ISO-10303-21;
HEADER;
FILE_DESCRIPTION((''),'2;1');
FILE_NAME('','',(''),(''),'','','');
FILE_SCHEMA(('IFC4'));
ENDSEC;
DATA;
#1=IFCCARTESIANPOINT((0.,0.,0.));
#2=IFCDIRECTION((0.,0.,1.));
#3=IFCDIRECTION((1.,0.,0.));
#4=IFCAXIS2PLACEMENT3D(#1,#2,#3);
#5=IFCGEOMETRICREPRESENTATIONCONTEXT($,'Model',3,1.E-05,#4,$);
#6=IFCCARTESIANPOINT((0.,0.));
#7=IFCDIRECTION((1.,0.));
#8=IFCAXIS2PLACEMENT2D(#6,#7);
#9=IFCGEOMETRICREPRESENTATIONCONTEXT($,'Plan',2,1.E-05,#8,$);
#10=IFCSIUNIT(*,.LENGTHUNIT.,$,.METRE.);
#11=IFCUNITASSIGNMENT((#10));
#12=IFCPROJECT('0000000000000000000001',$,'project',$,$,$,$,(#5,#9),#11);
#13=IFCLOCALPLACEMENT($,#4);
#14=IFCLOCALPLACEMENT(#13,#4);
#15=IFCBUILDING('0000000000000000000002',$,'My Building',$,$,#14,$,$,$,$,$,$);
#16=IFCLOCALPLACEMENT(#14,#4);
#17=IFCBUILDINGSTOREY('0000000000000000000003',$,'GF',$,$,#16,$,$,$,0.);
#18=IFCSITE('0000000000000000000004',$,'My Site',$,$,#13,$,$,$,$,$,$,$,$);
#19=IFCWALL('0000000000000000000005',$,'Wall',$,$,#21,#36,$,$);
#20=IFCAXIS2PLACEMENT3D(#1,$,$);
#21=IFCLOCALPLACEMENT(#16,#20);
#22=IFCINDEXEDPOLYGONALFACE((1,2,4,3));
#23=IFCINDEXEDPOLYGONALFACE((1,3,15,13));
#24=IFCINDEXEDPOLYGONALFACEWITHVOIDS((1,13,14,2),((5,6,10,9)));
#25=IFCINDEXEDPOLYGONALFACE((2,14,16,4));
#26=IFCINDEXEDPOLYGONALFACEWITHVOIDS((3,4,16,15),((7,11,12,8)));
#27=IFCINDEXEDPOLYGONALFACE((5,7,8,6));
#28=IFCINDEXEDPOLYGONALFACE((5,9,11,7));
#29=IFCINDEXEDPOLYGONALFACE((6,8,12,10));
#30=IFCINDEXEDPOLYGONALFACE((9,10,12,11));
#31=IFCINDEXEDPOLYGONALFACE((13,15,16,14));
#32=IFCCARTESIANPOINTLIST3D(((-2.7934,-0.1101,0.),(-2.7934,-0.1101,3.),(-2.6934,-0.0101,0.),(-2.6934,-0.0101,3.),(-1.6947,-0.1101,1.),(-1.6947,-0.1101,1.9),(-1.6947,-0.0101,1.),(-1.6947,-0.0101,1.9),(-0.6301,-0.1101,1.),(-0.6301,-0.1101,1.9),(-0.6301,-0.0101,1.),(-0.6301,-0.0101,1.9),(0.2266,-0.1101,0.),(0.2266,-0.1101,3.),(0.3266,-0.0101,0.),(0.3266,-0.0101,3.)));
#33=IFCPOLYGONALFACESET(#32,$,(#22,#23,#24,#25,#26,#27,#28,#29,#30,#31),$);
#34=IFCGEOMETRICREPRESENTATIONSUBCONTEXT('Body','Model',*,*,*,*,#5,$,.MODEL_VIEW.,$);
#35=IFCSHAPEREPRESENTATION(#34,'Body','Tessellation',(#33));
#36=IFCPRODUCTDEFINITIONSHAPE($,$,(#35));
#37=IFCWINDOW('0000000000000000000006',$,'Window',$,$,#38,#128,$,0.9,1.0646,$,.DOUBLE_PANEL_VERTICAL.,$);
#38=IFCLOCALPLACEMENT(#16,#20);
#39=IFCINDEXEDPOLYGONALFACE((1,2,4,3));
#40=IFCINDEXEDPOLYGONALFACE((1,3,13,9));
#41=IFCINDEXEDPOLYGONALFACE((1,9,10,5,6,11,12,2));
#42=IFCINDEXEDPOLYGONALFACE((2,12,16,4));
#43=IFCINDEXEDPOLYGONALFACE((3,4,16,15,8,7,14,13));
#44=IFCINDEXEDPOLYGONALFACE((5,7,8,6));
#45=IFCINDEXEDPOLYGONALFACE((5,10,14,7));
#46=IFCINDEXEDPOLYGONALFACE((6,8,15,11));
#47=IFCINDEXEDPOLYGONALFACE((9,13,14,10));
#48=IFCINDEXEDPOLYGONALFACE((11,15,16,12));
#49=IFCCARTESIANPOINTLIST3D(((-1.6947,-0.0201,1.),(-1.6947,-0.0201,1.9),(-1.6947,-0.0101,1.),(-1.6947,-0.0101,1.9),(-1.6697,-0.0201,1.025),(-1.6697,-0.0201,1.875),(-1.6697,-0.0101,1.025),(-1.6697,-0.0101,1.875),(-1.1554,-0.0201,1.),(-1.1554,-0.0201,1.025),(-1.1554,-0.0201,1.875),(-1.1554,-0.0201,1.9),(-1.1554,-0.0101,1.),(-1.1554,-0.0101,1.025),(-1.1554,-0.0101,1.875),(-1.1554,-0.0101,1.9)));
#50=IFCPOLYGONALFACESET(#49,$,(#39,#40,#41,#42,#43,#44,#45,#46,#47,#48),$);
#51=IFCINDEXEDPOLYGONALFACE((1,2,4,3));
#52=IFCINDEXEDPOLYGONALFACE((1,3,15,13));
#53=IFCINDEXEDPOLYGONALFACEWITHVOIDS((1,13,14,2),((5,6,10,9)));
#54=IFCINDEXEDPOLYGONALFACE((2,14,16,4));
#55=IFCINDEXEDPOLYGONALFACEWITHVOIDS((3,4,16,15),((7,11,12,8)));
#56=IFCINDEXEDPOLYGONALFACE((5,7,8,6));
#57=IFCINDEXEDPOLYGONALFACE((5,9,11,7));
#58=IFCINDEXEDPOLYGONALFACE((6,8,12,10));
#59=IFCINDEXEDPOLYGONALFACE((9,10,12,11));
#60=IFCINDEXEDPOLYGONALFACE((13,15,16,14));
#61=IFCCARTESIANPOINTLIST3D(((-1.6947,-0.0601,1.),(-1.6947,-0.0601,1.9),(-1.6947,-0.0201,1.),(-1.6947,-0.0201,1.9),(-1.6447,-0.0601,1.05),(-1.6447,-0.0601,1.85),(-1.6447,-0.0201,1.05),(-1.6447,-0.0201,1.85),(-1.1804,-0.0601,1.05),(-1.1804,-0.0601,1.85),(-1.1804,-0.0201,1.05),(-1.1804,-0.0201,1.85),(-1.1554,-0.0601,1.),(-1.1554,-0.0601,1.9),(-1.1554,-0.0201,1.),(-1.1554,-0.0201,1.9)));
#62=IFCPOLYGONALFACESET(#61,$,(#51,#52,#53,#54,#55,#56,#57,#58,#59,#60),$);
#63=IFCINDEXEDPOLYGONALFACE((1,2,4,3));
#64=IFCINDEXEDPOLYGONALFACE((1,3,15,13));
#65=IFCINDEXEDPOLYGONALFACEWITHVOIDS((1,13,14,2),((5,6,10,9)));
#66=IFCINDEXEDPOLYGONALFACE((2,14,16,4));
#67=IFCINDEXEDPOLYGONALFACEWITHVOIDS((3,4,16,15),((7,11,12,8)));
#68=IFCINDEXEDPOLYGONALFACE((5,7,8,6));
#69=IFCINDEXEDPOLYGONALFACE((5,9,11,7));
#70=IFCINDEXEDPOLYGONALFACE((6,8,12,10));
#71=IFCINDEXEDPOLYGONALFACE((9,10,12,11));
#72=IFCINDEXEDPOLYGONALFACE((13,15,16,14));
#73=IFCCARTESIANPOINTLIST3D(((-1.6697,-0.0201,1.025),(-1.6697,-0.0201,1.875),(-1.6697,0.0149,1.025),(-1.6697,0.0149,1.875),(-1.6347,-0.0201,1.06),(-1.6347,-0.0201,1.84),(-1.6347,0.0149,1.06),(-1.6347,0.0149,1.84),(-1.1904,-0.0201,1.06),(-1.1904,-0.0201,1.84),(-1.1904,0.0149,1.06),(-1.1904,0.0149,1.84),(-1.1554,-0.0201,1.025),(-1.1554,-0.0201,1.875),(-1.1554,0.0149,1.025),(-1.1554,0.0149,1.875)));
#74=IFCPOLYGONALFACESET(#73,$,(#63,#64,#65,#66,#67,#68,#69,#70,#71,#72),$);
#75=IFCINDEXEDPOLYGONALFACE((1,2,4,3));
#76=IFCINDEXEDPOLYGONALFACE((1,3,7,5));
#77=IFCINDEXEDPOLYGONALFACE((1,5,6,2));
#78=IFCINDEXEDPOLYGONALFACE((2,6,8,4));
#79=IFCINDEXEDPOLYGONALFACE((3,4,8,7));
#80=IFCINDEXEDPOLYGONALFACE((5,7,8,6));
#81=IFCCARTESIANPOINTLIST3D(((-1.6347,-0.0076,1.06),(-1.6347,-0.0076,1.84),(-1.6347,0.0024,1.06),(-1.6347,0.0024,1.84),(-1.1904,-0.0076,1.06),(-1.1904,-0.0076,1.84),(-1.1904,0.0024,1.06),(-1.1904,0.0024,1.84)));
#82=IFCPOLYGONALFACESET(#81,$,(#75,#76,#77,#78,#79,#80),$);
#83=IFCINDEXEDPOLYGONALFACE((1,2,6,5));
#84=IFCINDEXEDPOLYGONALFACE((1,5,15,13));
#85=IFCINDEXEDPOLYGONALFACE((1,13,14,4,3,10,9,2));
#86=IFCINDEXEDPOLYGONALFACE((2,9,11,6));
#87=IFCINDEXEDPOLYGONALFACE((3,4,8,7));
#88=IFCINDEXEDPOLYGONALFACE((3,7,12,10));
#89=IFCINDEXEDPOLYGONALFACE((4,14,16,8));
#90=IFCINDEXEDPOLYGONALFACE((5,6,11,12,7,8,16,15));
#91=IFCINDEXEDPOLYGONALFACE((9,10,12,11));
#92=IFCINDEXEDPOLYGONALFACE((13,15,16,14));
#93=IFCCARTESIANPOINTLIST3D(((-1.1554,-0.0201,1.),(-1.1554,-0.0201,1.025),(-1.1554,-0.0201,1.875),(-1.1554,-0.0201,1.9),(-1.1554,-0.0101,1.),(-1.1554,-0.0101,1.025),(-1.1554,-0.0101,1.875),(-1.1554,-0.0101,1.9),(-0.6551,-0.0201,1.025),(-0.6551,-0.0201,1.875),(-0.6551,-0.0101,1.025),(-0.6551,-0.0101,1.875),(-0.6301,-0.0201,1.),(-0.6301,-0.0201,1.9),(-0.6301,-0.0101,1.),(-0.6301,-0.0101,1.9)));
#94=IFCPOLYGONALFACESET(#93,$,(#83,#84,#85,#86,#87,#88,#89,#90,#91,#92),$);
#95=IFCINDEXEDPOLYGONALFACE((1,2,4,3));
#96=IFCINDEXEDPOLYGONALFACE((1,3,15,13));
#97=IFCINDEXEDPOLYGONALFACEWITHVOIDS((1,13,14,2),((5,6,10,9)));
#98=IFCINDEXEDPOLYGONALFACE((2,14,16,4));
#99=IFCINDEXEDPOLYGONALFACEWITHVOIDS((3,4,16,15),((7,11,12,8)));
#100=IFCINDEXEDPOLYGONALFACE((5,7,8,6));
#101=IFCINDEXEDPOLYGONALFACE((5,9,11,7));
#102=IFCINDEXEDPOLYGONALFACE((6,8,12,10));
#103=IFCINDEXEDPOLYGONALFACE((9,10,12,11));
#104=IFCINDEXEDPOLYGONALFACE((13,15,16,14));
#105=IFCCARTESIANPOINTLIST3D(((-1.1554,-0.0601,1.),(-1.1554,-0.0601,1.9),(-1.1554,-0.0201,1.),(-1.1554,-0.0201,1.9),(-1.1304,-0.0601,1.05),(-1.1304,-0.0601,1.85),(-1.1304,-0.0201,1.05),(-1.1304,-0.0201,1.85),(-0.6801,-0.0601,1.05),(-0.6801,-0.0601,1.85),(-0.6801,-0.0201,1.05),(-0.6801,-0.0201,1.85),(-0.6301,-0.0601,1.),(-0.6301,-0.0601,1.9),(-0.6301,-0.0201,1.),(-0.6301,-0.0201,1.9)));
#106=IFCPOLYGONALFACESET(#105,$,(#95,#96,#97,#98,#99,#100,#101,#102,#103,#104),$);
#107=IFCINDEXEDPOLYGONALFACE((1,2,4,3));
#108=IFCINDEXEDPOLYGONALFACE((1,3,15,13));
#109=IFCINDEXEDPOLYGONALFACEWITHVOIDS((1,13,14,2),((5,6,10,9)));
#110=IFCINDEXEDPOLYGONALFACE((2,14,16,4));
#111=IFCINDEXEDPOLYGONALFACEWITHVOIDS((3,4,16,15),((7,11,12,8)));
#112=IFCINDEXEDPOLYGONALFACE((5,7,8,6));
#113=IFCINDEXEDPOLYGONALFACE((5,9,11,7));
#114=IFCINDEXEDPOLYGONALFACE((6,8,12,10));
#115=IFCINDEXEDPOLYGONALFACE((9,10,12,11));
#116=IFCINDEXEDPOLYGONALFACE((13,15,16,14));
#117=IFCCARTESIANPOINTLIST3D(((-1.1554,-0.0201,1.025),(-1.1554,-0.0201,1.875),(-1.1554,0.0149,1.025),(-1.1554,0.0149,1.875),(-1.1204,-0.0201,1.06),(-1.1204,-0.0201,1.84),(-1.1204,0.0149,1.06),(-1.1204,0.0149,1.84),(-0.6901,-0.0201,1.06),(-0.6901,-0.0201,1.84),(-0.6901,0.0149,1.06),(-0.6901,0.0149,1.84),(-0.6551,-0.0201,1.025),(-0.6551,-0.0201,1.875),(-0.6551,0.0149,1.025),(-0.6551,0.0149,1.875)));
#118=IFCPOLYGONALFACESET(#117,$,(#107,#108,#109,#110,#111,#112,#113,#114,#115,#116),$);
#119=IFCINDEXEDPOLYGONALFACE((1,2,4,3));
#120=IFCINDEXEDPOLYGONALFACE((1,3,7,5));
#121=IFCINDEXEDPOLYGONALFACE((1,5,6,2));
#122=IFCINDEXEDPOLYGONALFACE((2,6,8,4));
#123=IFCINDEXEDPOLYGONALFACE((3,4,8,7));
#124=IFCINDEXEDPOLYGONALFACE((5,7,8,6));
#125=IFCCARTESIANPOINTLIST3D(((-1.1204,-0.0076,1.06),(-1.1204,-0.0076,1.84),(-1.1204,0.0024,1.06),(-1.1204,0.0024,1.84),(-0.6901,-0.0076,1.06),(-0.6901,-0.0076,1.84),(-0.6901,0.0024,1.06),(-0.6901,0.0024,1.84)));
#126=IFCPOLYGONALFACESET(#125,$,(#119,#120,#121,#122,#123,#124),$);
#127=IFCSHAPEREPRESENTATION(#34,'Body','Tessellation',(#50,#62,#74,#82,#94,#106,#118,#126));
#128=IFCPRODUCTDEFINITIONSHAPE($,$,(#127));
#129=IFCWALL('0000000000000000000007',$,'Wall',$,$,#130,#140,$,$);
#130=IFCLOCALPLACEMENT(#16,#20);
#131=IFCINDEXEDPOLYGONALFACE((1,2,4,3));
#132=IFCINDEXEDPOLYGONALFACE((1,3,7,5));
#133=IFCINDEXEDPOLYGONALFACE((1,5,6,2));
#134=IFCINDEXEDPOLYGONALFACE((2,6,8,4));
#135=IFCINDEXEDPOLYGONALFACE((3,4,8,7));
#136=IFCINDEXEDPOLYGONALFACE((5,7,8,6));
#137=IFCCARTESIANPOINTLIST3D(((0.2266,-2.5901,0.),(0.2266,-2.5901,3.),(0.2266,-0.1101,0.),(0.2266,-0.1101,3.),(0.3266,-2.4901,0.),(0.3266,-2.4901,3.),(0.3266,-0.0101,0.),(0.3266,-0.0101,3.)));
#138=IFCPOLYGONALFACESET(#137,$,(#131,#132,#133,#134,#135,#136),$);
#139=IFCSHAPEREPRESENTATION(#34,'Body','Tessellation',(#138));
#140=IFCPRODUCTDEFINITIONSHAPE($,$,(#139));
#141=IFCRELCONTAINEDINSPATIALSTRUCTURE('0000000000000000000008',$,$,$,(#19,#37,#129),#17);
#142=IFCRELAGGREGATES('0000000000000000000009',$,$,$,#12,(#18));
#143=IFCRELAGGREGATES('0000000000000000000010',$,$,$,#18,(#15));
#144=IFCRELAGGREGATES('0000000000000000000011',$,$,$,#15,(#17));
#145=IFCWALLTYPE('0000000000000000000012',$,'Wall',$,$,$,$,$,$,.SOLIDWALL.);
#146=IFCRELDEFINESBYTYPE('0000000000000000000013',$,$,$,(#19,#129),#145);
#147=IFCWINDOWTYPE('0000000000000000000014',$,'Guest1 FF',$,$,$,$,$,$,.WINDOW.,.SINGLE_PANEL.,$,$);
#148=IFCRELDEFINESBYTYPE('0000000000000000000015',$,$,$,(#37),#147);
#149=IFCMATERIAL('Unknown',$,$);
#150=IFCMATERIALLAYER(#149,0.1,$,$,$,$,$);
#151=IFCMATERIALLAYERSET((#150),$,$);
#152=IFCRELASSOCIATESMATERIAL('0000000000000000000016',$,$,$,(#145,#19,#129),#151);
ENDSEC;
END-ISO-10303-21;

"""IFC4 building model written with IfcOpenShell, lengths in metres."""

from ifc_helpers import new_model, entity, si_unit, frame, origin_with_axes, origin_2d_with_axis, place, context, subcontext, project, spatial, line, indexed_curve, outline, extrude, shape, source, transform, mapped, material, layer, layer_set, layer_usage, type_object, type_shapes, element, fill, save


model = new_model("IFC4")

# Units and contexts
model_context = context("Model", 3, precision=1e-05, world=origin_with_axes())
plan_context = context("Plan", 2, precision=1e-05, world=origin_2d_with_axis())
body_context_1 = subcontext(model_context, "Body", "Model", "MODEL_VIEW")
body_context_2 = subcontext(plan_context, "Body", "Plan", "PLAN_VIEW")
ifc_project = project(units=[si_unit("LENGTHUNIT", "METRE")], contexts=[model_context, plan_context])

# Site, building, storey
site_placement = place(None, origin_with_axes())
site = spatial("IfcSite", under=ifc_project, at=site_placement, Name="My Site")
building_placement = place(site_placement, origin_with_axes())
building = spatial("IfcBuilding", under=site, at=building_placement, Name="My Building")
storey_placement = place(building_placement, origin_with_axes())
storey = spatial("IfcBuildingStorey", under=building, at=storey_placement, Name="GF", Elevation=0.0)

# Shared definitions
ifc_material = material(Name="Unknown")

# Shared definitions
ifc_layer_1 = layer(ifc_material, 0.1)
ifc_layer_set_1 = layer_set([ifc_layer_1])
wall_type = type_object("IfcWallType", Name="Wall", PredefinedType="SOLIDWALL", material=ifc_layer_set_1)

# Wall, opening, window
ifc_layer_usage_1 = layer_usage(ifc_layer_set_1, "AXIS2", "POSITIVE", 0.0)
wall_1_placement = place(storey_placement, frame((-2.7934, -0.1101, 0.0), z_axis=(0.0, 0.0, 1.0), x_axis=(1.0, 0.0, 0.0)))
wall_1 = element("IfcWall", 1, at=wall_1_placement, inside=storey, type_object=wall_type, material=ifc_layer_usage_1, Name="Wall", context=body_context_1, shape_type="SweptSolid", body=[
    extrude(outline(indexed_curve([(0.0, 0.0), (0.1, 0.1), (3.12, 0.1), (3.02, 0.0)], segments=[line(1, 2, 3, 4, 1)])), origin_with_axes(), (0.0, 0.0, 1.0), 3.0),
])
shared_shape_1 = source(origin_with_axes(), body_context_1, "Body", "SweptSolid", [
    extrude(outline(indexed_curve([(0.0, 0.0), (1.0646, 0.0), (1.0646, 0.9), (0.0, 0.9)], segments=[line(1, 2, 3, 4, 1)])), frame((0.0, -0.6, 0.0), z_axis=(0.0, -1.0, 0.0), x_axis=(1.0, 0.0, 0.0)), (0.0, 0.0, -1.0), 1.2),
])
opening_1_placement = place(wall_1_placement, frame((1.0987, 0.0, 1.0), z_axis=(0.0, 0.0, 1.0), x_axis=(1.0, 0.0, 0.0)))
opening_1 = element("IfcOpeningElement", 2, at=opening_1_placement, cuts=wall_1, PredefinedType="OPENING", context=body_context_1, shape_type="MappedRepresentation", body=[
    mapped(shared_shape_1, transform((0.0, 0.0, 0.0), x_axis=(1.0, 0.0, 0.0), y_axis=(0.0, 1.0, 0.0), z_axis=(0.0, 0.0, 1.0), scale=1.0)),
])
window_type_1 = type_object("IfcWindowType", Name="Guest1 FF", PartitioningType="SINGLE_PANEL", PredefinedType="WINDOW")
shared_shape_2 = source(origin_with_axes(), body_context_1, "Body", "SweptSolid", [
    extrude(outline(indexed_curve([(0.5393, 0.0), (0.0, 0.0), (0.0, 0.9), (0.5393, 0.9), (0.5393, 0.875), (0.025, 0.875), (0.025, 0.025), (0.5393, 0.025)], segments=[line(1, 2, 3, 4, 5, 6, 7, 8, 1)])), frame((0.0, 0.09, 0.0), z_axis=(0.0, -1.0, 0.0), x_axis=(1.0, 0.0, 0.0)), (0.0, 0.0, -1.0), 0.01),
    extrude(outline(indexed_curve([(0.0, 0.0), (0.5393, 0.0), (0.5393, 0.9), (0.0, 0.9)], segments=[line(1, 2, 3, 4, 1)]), holes=[indexed_curve([(0.05, 0.05), (0.5143, 0.05), (0.5143, 0.85), (0.05, 0.85)], segments=[line(1, 2, 3, 4, 1)])]), frame((0.0, 0.05, 0.0), z_axis=(0.0, -1.0, 0.0), x_axis=(1.0, 0.0, 0.0)), (0.0, 0.0, -1.0), 0.04),
    extrude(outline(indexed_curve([(0.0, 0.0), (0.5143, 0.0), (0.5143, 0.85), (0.0, 0.85)], segments=[line(1, 2, 3, 4, 1)]), holes=[indexed_curve([(0.035, 0.035), (0.4793, 0.035), (0.4793, 0.815), (0.035, 0.815)], segments=[line(1, 2, 3, 4, 1)])]), frame((0.025, 0.09, 0.025), z_axis=(0.0, -1.0, 0.0), x_axis=(1.0, 0.0, 0.0)), (0.0, 0.0, -1.0), 0.035),
    extrude(outline(indexed_curve([(0.035, 0.035), (0.4793, 0.035), (0.4793, 0.815), (0.035, 0.815)], segments=[line(1, 2, 3, 4, 1)])), frame((0.025, 0.1025, 0.025), z_axis=(0.0, -1.0, 0.0), x_axis=(1.0, 0.0, 0.0)), (0.0, 0.0, -1.0), 0.01),
    extrude(outline(indexed_curve([(0.0, 0.9), (0.5253, 0.9), (0.5253, 0.0), (0.0, 0.0), (0.0, 0.025), (0.5003, 0.025), (0.5003, 0.875), (0.0, 0.875)], segments=[line(1, 2, 3, 4, 5, 6, 7, 8, 1)])), frame((0.5393, 0.09, 0.0), z_axis=(0.0, -1.0, 0.0), x_axis=(1.0, 0.0, 0.0)), (0.0, 0.0, -1.0), 0.01),
    extrude(outline(indexed_curve([(0.0, 0.0), (0.5253, 0.0), (0.5253, 0.9), (0.0, 0.9)], segments=[line(1, 2, 3, 4, 1)]), holes=[indexed_curve([(0.025, 0.05), (0.4753, 0.05), (0.4753, 0.85), (0.025, 0.85)], segments=[line(1, 2, 3, 4, 1)])]), frame((0.5393, 0.05, 0.0), z_axis=(0.0, -1.0, 0.0), x_axis=(1.0, 0.0, 0.0)), (0.0, 0.0, -1.0), 0.04),
    extrude(outline(indexed_curve([(0.0, 0.0), (0.5003, 0.0), (0.5003, 0.85), (0.0, 0.85)], segments=[line(1, 2, 3, 4, 1)]), holes=[indexed_curve([(0.035, 0.035), (0.4653, 0.035), (0.4653, 0.815), (0.035, 0.815)], segments=[line(1, 2, 3, 4, 1)])]), frame((0.5393, 0.09, 0.025), z_axis=(0.0, -1.0, 0.0), x_axis=(1.0, 0.0, 0.0)), (0.0, 0.0, -1.0), 0.035),
    extrude(outline(indexed_curve([(0.035, 0.035), (0.4653, 0.035), (0.4653, 0.815), (0.035, 0.815)], segments=[line(1, 2, 3, 4, 1)])), frame((0.5393, 0.1025, 0.025), z_axis=(0.0, -1.0, 0.0), x_axis=(1.0, 0.0, 0.0)), (0.0, 0.0, -1.0), 0.01),
])
shared_shape_3 = source(origin_with_axes(), body_context_2, "Body", "Curve2D", [
    entity("IfcIndexedPolyCurve", entity("IfcCartesianPointList2D", [[0.05, 0.05], [0.5143, 0.05]])),
    entity("IfcIndexedPolyCurve", entity("IfcCartesianPointList2D", [[0.0, 0.1], [0.025, 0.1], [0.025, 0.09], [0.05, 0.09], [0.05, 0.05], [0.0, 0.05]]), [entity("IfcLineIndex", [1, 2, 3, 4, 5, 6, 1])]),
    entity("IfcIndexedPolyCurve", entity("IfcCartesianPointList2D", [[0.5393, 0.1], [0.5393, 0.1], [0.5393, 0.09], [0.5143, 0.09], [0.5143, 0.05], [0.5393, 0.05]])),
    entity("IfcIndexedPolyCurve", entity("IfcCartesianPointList2D", [[0.025, 0.09], [0.06, 0.09], [0.06, 0.125], [0.025, 0.125]]), [entity("IfcLineIndex", [1, 2, 3, 4, 1])]),
    entity("IfcIndexedPolyCurve", entity("IfcCartesianPointList2D", [[0.5393, 0.09], [0.5043, 0.09], [0.5043, 0.125], [0.5393, 0.125]]), [entity("IfcLineIndex", [1, 2, 3, 4, 1])]),
    entity("IfcIndexedPolyCurve", entity("IfcCartesianPointList2D", [[0.06, 0.09], [0.5043, 0.09]])),
    entity("IfcIndexedPolyCurve", entity("IfcCartesianPointList2D", [[0.06, 0.125], [0.5043, 0.125]])),
    entity("IfcIndexedPolyCurve", entity("IfcCartesianPointList2D", [[0.06, 0.1075], [0.5043, 0.1075]])),
    entity("IfcIndexedPolyCurve", entity("IfcCartesianPointList2D", [[0.5643, 0.05], [1.0146, 0.05]])),
    entity("IfcIndexedPolyCurve", entity("IfcCartesianPointList2D", [[0.5393, 0.1], [0.5393, 0.1], [0.5393, 0.09], [0.5643, 0.09], [0.5643, 0.05], [0.5393, 0.05]])),
    entity("IfcIndexedPolyCurve", entity("IfcCartesianPointList2D", [[1.0646, 0.1], [1.0396, 0.1], [1.0396, 0.09], [1.0146, 0.09], [1.0146, 0.05], [1.0646, 0.05]]), [entity("IfcLineIndex", [1, 2, 3, 4, 5, 6, 1])]),
    entity("IfcIndexedPolyCurve", entity("IfcCartesianPointList2D", [[0.5393, 0.09], [0.5743, 0.09], [0.5743, 0.125], [0.5393, 0.125]]), [entity("IfcLineIndex", [1, 2, 3, 4, 1])]),
    entity("IfcIndexedPolyCurve", entity("IfcCartesianPointList2D", [[1.0396, 0.09], [1.0046, 0.09], [1.0046, 0.125], [1.0396, 0.125]]), [entity("IfcLineIndex", [1, 2, 3, 4, 1])]),
    entity("IfcIndexedPolyCurve", entity("IfcCartesianPointList2D", [[0.5743, 0.09], [1.0046, 0.09]])),
    entity("IfcIndexedPolyCurve", entity("IfcCartesianPointList2D", [[0.5743, 0.125], [1.0046, 0.125]])),
    entity("IfcIndexedPolyCurve", entity("IfcCartesianPointList2D", [[0.5743, 0.1075], [1.0046, 0.1075]])),
])
type_shapes(window_type_1, [shared_shape_2, shared_shape_3])
window_1_placement = place(opening_1_placement, origin_with_axes())
window_1 = element("IfcWindow", 3, at=window_1_placement, inside=storey, type_object=window_type_1, Name="Window", OverallHeight=0.9, OverallWidth=1.0646, PartitioningType="DOUBLE_PANEL_VERTICAL", shapes=[
    shape(body_context_1, "Body", "MappedRepresentation", [mapped(shared_shape_2, transform((0.0, 0.0, 0.0), x_axis=(1.0, 0.0, 0.0), y_axis=(0.0, 1.0, 0.0), z_axis=(0.0, 0.0, 1.0), scale=1.0))]),
    shape(body_context_2, "Body", "MappedRepresentation", [mapped(shared_shape_3, transform((0.0, 0.0, 0.0), x_axis=(1.0, 0.0, 0.0), y_axis=(0.0, 1.0, 0.0), z_axis=(0.0, 0.0, 1.0), scale=1.0))]),
])
fill(opening_1, window_1)

# Wall
ifc_layer_usage_2 = layer_usage(ifc_layer_set_1, "AXIS2", "POSITIVE", 0.0)
wall_2_placement = place(storey_placement, frame((0.2266, -0.1101, 0.0), z_axis=(0.0, 0.0, 1.0), x_axis=(0.0, -1.0, 0.0)))
element("IfcWall", 4, at=wall_2_placement, inside=storey, type_object=wall_type, material=ifc_layer_usage_2, Name="Wall", context=body_context_1, shape_type="SweptSolid", body=[
    extrude(outline(indexed_curve([(0.0, 0.0), (-0.1, 0.1), (2.38, 0.1), (2.48, 0.0)], segments=[line(1, 2, 3, 4, 1)])), origin_with_axes(), (0.0, 0.0, 1.0), 3.0),
])

save(model, "model.ifc")
